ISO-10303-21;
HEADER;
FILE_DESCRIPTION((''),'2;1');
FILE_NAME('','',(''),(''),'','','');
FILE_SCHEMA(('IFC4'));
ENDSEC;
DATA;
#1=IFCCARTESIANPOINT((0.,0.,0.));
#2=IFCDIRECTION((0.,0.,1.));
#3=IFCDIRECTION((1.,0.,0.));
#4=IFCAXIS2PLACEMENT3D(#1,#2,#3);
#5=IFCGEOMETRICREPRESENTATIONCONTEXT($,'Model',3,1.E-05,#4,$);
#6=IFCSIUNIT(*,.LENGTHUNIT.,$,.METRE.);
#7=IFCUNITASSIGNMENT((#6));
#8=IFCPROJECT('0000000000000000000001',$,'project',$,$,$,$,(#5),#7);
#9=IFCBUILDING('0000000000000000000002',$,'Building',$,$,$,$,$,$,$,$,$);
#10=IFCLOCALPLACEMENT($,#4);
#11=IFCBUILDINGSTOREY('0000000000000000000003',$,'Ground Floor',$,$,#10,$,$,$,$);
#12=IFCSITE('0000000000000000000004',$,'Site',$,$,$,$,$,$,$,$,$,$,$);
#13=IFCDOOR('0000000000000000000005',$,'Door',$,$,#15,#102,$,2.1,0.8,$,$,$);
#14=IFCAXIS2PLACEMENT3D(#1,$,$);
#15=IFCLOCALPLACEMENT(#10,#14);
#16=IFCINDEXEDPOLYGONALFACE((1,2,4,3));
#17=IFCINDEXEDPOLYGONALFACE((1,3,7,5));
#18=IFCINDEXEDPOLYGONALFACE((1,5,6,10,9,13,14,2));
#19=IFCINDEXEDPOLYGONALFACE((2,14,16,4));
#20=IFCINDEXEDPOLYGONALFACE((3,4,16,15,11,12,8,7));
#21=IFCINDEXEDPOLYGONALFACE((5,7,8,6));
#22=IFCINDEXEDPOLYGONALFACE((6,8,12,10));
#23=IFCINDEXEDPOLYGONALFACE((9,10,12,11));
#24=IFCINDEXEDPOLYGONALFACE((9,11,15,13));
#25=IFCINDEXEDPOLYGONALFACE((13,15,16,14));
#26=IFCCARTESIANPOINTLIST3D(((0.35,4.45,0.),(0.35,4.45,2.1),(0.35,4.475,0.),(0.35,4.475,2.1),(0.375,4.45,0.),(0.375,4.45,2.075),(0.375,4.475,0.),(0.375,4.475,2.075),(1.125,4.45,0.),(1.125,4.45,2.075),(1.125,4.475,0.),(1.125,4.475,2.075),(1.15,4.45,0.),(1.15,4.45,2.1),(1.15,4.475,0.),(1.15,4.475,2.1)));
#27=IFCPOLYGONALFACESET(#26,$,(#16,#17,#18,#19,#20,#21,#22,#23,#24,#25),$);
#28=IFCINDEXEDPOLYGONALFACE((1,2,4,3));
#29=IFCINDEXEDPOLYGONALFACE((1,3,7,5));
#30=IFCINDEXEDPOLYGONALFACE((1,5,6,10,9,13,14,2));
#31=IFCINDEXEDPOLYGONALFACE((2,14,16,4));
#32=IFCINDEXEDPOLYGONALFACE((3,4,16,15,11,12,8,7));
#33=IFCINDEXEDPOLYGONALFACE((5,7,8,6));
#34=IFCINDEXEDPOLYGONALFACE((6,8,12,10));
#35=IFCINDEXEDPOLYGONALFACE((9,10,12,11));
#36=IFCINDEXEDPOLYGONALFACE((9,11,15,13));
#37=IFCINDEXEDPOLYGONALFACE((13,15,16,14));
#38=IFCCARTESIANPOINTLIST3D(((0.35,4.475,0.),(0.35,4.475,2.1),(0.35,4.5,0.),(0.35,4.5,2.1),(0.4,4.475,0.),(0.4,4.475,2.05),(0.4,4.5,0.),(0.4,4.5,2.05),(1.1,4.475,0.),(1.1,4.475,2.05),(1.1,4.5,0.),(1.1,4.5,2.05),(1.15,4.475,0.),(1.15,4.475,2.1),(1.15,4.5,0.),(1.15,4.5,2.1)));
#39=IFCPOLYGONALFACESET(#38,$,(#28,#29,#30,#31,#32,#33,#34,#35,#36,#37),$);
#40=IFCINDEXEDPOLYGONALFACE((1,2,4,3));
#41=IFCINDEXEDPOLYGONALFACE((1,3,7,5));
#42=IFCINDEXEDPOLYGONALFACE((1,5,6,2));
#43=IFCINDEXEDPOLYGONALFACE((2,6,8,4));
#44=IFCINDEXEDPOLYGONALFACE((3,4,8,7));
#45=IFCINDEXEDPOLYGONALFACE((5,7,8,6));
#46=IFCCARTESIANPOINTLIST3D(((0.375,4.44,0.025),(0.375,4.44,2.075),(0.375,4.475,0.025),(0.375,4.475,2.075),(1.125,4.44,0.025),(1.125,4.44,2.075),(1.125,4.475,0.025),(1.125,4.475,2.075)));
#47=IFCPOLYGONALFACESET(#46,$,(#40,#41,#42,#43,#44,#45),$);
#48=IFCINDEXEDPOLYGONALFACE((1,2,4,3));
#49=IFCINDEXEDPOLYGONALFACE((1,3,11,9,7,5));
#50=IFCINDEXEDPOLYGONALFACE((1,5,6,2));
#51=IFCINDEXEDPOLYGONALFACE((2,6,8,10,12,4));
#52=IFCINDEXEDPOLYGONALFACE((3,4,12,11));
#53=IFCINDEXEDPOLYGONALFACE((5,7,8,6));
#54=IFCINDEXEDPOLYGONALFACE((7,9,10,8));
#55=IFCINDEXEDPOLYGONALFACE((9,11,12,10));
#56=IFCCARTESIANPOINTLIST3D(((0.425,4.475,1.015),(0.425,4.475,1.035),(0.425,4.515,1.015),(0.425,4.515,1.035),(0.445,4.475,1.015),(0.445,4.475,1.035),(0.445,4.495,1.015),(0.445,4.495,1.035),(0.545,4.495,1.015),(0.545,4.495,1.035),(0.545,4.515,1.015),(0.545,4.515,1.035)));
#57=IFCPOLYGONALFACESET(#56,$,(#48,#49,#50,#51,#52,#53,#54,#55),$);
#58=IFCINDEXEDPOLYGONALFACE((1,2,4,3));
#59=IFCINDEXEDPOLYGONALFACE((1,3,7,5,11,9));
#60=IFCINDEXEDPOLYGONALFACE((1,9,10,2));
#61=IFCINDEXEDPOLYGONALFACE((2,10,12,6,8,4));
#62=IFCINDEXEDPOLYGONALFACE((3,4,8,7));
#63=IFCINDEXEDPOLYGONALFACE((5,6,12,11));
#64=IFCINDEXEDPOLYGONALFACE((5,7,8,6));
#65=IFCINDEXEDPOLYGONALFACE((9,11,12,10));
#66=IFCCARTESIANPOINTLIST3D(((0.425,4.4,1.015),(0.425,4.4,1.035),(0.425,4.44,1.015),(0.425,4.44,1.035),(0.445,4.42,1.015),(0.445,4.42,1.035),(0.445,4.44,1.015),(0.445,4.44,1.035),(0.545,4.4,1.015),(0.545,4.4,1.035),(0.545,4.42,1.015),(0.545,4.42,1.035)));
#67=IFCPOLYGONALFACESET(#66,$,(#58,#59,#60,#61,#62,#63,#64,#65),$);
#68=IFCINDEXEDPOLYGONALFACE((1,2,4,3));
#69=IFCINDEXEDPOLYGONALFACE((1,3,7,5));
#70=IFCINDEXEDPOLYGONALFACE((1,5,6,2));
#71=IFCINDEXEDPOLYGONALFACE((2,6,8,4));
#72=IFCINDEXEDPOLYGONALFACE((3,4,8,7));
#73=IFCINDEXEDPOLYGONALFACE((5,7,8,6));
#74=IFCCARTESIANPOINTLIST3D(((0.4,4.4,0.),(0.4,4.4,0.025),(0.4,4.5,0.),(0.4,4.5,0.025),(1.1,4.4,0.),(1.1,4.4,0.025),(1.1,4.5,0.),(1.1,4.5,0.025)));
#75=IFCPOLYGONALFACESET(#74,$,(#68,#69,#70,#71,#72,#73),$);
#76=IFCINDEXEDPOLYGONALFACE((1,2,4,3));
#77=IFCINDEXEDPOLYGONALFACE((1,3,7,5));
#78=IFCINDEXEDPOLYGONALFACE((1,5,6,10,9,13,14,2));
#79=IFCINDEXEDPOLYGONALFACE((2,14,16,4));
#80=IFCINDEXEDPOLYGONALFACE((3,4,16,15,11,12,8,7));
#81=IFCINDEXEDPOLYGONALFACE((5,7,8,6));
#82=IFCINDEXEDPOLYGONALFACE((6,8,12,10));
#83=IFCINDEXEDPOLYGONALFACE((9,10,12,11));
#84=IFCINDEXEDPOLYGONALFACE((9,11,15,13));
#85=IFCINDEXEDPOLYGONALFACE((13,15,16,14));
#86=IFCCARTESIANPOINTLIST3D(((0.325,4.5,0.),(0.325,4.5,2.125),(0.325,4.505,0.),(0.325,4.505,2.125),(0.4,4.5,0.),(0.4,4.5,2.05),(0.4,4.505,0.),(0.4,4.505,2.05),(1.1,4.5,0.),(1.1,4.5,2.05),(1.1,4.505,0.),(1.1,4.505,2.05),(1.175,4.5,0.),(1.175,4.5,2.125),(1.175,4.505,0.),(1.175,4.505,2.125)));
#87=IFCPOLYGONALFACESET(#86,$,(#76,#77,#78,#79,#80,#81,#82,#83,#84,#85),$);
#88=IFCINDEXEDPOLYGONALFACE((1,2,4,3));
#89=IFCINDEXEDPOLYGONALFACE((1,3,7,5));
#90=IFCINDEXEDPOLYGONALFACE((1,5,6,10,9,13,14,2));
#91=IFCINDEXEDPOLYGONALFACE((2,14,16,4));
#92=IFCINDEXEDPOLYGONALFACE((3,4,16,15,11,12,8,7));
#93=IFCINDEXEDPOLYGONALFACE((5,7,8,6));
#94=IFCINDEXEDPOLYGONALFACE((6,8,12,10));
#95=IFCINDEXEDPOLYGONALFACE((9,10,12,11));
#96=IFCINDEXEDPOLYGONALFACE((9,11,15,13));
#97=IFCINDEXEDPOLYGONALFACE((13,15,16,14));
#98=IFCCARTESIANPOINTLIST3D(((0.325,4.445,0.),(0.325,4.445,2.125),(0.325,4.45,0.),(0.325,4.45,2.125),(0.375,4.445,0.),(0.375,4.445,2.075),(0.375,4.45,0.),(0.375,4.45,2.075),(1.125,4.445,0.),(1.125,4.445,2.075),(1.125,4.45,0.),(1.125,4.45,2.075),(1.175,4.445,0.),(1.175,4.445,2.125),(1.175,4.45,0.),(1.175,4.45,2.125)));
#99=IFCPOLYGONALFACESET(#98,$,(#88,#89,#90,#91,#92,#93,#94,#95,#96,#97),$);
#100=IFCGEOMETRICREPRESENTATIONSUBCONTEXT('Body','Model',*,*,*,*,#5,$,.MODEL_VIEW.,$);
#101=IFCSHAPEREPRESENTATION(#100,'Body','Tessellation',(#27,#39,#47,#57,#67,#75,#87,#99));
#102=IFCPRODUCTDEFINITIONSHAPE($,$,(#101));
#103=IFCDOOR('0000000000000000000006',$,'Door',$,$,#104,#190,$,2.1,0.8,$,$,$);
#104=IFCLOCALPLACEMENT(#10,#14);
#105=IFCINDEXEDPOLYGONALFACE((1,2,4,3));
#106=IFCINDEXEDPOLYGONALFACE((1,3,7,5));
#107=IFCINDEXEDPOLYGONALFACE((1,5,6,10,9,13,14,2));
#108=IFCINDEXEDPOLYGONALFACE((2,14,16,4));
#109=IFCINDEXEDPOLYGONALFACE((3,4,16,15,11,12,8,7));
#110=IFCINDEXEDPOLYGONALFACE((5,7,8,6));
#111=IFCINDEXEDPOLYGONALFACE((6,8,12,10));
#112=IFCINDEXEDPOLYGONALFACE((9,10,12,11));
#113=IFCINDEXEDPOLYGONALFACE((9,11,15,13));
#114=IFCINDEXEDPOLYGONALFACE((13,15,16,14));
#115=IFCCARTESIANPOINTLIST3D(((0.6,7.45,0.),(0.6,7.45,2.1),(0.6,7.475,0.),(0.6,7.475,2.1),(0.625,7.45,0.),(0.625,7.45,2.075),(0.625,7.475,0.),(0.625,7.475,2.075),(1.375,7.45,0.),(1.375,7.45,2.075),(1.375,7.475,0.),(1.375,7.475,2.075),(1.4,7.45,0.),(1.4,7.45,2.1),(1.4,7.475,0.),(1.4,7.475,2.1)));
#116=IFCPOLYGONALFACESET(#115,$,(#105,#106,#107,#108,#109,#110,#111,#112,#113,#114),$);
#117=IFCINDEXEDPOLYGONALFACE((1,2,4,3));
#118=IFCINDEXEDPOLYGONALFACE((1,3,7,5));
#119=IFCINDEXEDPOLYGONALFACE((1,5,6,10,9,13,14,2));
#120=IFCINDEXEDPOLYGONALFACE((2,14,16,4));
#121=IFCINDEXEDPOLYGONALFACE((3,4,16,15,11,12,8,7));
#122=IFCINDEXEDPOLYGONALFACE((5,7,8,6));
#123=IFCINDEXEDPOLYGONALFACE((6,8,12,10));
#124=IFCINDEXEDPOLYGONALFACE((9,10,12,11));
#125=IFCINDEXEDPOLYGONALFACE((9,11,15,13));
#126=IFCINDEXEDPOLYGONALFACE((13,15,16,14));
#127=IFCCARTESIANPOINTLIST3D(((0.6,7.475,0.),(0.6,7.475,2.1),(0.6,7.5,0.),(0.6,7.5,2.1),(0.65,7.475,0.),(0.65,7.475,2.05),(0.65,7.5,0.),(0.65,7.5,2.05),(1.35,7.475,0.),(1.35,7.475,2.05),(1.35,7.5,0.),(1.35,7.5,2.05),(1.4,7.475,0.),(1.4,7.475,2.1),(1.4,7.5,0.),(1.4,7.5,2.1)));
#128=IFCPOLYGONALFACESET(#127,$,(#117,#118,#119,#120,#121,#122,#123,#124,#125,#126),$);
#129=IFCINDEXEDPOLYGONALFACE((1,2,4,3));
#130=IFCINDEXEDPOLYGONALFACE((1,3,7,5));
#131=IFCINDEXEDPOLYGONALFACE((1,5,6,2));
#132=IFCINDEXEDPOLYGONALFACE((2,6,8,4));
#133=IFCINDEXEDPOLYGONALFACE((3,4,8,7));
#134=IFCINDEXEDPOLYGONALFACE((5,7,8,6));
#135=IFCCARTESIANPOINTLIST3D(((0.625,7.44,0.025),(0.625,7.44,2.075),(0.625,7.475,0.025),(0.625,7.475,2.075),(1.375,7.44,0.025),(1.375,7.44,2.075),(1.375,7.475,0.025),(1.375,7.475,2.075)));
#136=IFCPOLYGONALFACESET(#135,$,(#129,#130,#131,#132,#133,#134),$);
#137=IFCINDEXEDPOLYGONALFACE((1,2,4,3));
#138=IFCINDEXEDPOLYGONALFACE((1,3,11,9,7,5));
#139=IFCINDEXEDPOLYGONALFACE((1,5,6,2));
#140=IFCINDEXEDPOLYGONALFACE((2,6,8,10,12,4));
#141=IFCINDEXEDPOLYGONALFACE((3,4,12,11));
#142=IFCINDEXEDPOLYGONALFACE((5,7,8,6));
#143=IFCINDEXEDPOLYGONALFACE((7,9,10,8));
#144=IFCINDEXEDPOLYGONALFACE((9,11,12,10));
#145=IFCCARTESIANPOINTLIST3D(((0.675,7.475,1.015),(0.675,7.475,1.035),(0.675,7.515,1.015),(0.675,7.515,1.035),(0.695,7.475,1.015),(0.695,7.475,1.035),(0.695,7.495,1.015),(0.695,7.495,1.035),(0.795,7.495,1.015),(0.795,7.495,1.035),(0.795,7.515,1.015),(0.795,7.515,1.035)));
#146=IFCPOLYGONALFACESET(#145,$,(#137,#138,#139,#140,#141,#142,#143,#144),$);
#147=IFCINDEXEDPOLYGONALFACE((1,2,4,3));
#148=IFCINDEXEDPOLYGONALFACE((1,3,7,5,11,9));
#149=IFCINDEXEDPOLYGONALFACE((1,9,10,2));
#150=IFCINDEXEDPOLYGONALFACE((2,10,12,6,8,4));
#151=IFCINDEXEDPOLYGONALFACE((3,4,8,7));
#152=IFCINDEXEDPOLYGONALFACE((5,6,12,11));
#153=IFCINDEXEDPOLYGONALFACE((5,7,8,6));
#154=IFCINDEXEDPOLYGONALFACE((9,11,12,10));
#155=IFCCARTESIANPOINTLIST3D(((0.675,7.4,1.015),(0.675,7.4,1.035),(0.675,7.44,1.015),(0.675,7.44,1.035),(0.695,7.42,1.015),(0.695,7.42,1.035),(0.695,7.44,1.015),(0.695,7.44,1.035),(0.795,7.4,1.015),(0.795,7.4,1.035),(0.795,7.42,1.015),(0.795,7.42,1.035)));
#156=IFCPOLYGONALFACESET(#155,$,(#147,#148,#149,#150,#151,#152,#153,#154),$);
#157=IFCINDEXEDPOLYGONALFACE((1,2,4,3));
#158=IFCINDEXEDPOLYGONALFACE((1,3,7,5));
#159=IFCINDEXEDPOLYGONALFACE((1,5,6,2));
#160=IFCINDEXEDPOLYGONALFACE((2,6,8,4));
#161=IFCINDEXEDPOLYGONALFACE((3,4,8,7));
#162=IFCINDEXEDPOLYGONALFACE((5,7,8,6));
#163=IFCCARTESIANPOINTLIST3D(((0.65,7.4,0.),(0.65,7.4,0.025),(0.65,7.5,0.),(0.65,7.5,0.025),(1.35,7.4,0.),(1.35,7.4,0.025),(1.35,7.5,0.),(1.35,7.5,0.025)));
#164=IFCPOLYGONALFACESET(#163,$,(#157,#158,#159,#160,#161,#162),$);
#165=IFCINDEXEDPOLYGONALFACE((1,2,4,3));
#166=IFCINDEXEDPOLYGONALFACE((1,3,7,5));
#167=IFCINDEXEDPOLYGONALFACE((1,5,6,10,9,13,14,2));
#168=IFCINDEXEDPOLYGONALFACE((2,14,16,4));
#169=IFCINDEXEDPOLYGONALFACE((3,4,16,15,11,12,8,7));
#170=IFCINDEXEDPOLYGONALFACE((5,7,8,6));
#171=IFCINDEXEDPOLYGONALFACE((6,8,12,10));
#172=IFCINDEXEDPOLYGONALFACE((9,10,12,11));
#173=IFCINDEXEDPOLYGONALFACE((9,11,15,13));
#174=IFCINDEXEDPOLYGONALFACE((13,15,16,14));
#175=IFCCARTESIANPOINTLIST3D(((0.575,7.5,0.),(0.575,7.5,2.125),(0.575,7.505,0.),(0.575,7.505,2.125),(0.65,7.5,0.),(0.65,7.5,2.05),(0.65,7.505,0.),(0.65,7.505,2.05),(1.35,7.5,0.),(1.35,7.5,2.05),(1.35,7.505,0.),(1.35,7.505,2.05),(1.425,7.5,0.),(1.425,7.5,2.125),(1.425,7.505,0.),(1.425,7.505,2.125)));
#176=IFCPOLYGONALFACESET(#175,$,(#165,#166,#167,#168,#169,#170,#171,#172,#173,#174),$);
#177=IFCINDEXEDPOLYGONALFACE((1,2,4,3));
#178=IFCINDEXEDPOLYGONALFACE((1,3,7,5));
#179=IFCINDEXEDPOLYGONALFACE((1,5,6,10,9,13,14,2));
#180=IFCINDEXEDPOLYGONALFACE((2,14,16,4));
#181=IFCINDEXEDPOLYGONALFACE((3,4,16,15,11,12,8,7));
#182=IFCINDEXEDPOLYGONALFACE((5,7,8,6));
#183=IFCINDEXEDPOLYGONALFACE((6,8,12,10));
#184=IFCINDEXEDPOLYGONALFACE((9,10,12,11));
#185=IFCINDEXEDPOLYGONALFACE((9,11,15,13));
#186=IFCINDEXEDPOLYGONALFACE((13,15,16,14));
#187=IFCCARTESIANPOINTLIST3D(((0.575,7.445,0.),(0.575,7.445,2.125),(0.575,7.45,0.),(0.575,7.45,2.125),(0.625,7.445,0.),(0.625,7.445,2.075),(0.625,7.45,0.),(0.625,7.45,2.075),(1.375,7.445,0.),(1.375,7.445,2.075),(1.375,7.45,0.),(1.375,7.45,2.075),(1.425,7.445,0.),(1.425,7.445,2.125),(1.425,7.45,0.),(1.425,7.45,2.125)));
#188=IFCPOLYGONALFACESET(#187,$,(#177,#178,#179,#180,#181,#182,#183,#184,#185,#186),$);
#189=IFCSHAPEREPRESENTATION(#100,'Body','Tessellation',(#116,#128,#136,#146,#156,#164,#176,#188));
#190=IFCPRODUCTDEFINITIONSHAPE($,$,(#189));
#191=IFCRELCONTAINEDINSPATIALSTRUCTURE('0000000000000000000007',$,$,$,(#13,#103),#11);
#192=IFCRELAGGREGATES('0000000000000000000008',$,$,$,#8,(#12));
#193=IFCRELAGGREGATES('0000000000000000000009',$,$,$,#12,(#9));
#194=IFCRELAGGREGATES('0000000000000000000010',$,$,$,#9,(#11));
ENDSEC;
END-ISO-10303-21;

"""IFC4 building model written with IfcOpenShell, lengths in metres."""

from ifc_helpers import new_model, si_unit, frame, origin_with_axes, place, context, subcontext, project, spatial, line, indexed_curve, outline, extrude, element, save


model = new_model("IFC4")

# Units and contexts
model_context = context("Model", 3, precision=1e-05, world=origin_with_axes())
body_context = subcontext(model_context, "Body", "Model", "MODEL_VIEW")
ifc_project = project(units=[si_unit("LENGTHUNIT", "METRE")], contexts=[model_context])

# Site, building, storey
site = spatial("IfcSite", under=ifc_project, Name="Site")
building = spatial("IfcBuilding", under=site, Name="Building")
storey_placement = place(None, origin_with_axes())
storey = spatial("IfcBuildingStorey", under=building, at=storey_placement, Name="Ground Floor")

# Doors
door_1_placement = place(storey_placement, frame((1.15, 4.5, 0.0), z_axis=(0.0, 0.0, 1.0), x_axis=(-1.0, 0.0, 0.0)))
element("IfcDoor", 1, at=door_1_placement, inside=storey, Name="Door", OverallHeight=2.1, OverallWidth=0.8, context=body_context, shape_type="SweptSolid", body=[
    extrude(outline(indexed_curve([(0.0, 0.0), (0.0, 2.1), (0.8, 2.1), (0.8, 0.0), (0.775, 0.0), (0.775, 2.075), (0.025, 2.075), (0.025, 0.0)], segments=[line(1, 2, 3, 4, 5, 6, 7, 8, 1)])), frame((0.0, 0.025, 0.0), z_axis=(0.0, -1.0, 0.0), x_axis=(1.0, 0.0, 0.0)), (0.0, 0.0, -1.0), 0.025),
    extrude(outline(indexed_curve([(0.0, 0.0), (0.0, 2.1), (0.8, 2.1), (0.8, 0.0), (0.75, 0.0), (0.75, 2.05), (0.05, 2.05), (0.05, 0.0)], segments=[line(1, 2, 3, 4, 5, 6, 7, 8, 1)])), frame((0.0, 0.0, 0.0), z_axis=(0.0, -1.0, 0.0), x_axis=(1.0, 0.0, 0.0)), (0.0, 0.0, -1.0), 0.025),
    extrude(outline(indexed_curve([(0.0, 0.0), (0.75, 0.0), (0.75, 0.035), (0.0, 0.035)], segments=[line(1, 2, 3, 4, 1)])), frame((0.025, 0.025, 0.025), z_axis=(0.0, 0.0, 1.0), x_axis=(1.0, 0.0, 0.0)), (0.0, 0.0, 1.0), 2.05),
    extrude(outline(indexed_curve([(0.0, 0.0), (0.0, -0.04), (-0.12, -0.04), (-0.12, -0.02), (-0.02, -0.02), (-0.02, 0.0)], segments=[line(1, 2, 3, 4, 5, 6, 1)])), frame((0.725, 0.025, 1.015), z_axis=(0.0, 0.0, 1.0), x_axis=(1.0, 0.0, 0.0)), (0.0, 0.0, 1.0), 0.02),
    extrude(outline(indexed_curve([(0.0, 0.0), (0.0, 0.04), (-0.12, 0.04), (-0.12, 0.02), (-0.02, 0.02), (-0.02, 0.0)], segments=[line(1, 2, 3, 4, 5, 6, 1)])), frame((0.725, 0.06, 1.015), z_axis=(0.0, 0.0, 1.0), x_axis=(1.0, 0.0, 0.0)), (0.0, 0.0, 1.0), 0.02),
    extrude(outline(indexed_curve([(0.0, 0.0), (0.7, 0.0), (0.7, 0.1), (0.0, 0.1)], segments=[line(1, 2, 3, 4, 1)])), frame((0.05, 0.0, 0.0), z_axis=(0.0, 0.0, 1.0), x_axis=(1.0, 0.0, 0.0)), (0.0, 0.0, 1.0), 0.025),
    extrude(outline(indexed_curve([(0.0, 0.0), (0.0, 2.125), (0.85, 2.125), (0.85, 0.0), (0.775, 0.0), (0.775, 2.05), (0.075, 2.05), (0.075, 0.0)], segments=[line(1, 2, 3, 4, 5, 6, 7, 8, 1)])), frame((-0.025, -0.005, 0.0), z_axis=(0.0, -1.0, 0.0), x_axis=(1.0, 0.0, 0.0)), (0.0, 0.0, -1.0), 0.005),
    extrude(outline(indexed_curve([(0.0, 0.0), (0.0, 2.125), (0.85, 2.125), (0.85, 0.0), (0.8, 0.0), (0.8, 2.075), (0.05, 2.075), (0.05, 0.0)], segments=[line(1, 2, 3, 4, 5, 6, 7, 8, 1)])), frame((-0.025, 0.05, 0.0), z_axis=(0.0, -1.0, 0.0), x_axis=(1.0, 0.0, 0.0)), (0.0, 0.0, -1.0), 0.005),
])
door_2_placement = place(storey_placement, frame((1.4, 7.5, 0.0), z_axis=(0.0, 0.0, 1.0), x_axis=(-1.0, 0.0, 0.0)))
element("IfcDoor", 2, at=door_2_placement, inside=storey, Name="Door", OverallHeight=2.1, OverallWidth=0.8, context=body_context, shape_type="SweptSolid", body=[
    extrude(outline(indexed_curve([(0.0, 0.0), (0.0, 2.1), (0.8, 2.1), (0.8, 0.0), (0.775, 0.0), (0.775, 2.075), (0.025, 2.075), (0.025, 0.0)], segments=[line(1, 2, 3, 4, 5, 6, 7, 8, 1)])), frame((0.0, 0.025, 0.0), z_axis=(0.0, -1.0, 0.0), x_axis=(1.0, 0.0, 0.0)), (0.0, 0.0, -1.0), 0.025),
    extrude(outline(indexed_curve([(0.0, 0.0), (0.0, 2.1), (0.8, 2.1), (0.8, 0.0), (0.75, 0.0), (0.75, 2.05), (0.05, 2.05), (0.05, 0.0)], segments=[line(1, 2, 3, 4, 5, 6, 7, 8, 1)])), frame((0.0, 0.0, 0.0), z_axis=(0.0, -1.0, 0.0), x_axis=(1.0, 0.0, 0.0)), (0.0, 0.0, -1.0), 0.025),
    extrude(outline(indexed_curve([(0.0, 0.0), (0.75, 0.0), (0.75, 0.035), (0.0, 0.035)], segments=[line(1, 2, 3, 4, 1)])), frame((0.025, 0.025, 0.025), z_axis=(0.0, 0.0, 1.0), x_axis=(1.0, 0.0, 0.0)), (0.0, 0.0, 1.0), 2.05),
    extrude(outline(indexed_curve([(0.0, 0.0), (0.0, -0.04), (-0.12, -0.04), (-0.12, -0.02), (-0.02, -0.02), (-0.02, 0.0)], segments=[line(1, 2, 3, 4, 5, 6, 1)])), frame((0.725, 0.025, 1.015), z_axis=(0.0, 0.0, 1.0), x_axis=(1.0, 0.0, 0.0)), (0.0, 0.0, 1.0), 0.02),
    extrude(outline(indexed_curve([(0.0, 0.0), (0.0, 0.04), (-0.12, 0.04), (-0.12, 0.02), (-0.02, 0.02), (-0.02, 0.0)], segments=[line(1, 2, 3, 4, 5, 6, 1)])), frame((0.725, 0.06, 1.015), z_axis=(0.0, 0.0, 1.0), x_axis=(1.0, 0.0, 0.0)), (0.0, 0.0, 1.0), 0.02),
    extrude(outline(indexed_curve([(0.0, 0.0), (0.7, 0.0), (0.7, 0.1), (0.0, 0.1)], segments=[line(1, 2, 3, 4, 1)])), frame((0.05, 0.0, 0.0), z_axis=(0.0, 0.0, 1.0), x_axis=(1.0, 0.0, 0.0)), (0.0, 0.0, 1.0), 0.025),
    extrude(outline(indexed_curve([(0.0, 0.0), (0.0, 2.125), (0.85, 2.125), (0.85, 0.0), (0.775, 0.0), (0.775, 2.05), (0.075, 2.05), (0.075, 0.0)], segments=[line(1, 2, 3, 4, 5, 6, 7, 8, 1)])), frame((-0.025, -0.005, 0.0), z_axis=(0.0, -1.0, 0.0), x_axis=(1.0, 0.0, 0.0)), (0.0, 0.0, -1.0), 0.005),
    extrude(outline(indexed_curve([(0.0, 0.0), (0.0, 2.125), (0.85, 2.125), (0.85, 0.0), (0.8, 0.0), (0.8, 2.075), (0.05, 2.075), (0.05, 0.0)], segments=[line(1, 2, 3, 4, 5, 6, 7, 8, 1)])), frame((-0.025, 0.05, 0.0), z_axis=(0.0, -1.0, 0.0), x_axis=(1.0, 0.0, 0.0)), (0.0, 0.0, -1.0), 0.005),
])

save(model, "model.ifc")
